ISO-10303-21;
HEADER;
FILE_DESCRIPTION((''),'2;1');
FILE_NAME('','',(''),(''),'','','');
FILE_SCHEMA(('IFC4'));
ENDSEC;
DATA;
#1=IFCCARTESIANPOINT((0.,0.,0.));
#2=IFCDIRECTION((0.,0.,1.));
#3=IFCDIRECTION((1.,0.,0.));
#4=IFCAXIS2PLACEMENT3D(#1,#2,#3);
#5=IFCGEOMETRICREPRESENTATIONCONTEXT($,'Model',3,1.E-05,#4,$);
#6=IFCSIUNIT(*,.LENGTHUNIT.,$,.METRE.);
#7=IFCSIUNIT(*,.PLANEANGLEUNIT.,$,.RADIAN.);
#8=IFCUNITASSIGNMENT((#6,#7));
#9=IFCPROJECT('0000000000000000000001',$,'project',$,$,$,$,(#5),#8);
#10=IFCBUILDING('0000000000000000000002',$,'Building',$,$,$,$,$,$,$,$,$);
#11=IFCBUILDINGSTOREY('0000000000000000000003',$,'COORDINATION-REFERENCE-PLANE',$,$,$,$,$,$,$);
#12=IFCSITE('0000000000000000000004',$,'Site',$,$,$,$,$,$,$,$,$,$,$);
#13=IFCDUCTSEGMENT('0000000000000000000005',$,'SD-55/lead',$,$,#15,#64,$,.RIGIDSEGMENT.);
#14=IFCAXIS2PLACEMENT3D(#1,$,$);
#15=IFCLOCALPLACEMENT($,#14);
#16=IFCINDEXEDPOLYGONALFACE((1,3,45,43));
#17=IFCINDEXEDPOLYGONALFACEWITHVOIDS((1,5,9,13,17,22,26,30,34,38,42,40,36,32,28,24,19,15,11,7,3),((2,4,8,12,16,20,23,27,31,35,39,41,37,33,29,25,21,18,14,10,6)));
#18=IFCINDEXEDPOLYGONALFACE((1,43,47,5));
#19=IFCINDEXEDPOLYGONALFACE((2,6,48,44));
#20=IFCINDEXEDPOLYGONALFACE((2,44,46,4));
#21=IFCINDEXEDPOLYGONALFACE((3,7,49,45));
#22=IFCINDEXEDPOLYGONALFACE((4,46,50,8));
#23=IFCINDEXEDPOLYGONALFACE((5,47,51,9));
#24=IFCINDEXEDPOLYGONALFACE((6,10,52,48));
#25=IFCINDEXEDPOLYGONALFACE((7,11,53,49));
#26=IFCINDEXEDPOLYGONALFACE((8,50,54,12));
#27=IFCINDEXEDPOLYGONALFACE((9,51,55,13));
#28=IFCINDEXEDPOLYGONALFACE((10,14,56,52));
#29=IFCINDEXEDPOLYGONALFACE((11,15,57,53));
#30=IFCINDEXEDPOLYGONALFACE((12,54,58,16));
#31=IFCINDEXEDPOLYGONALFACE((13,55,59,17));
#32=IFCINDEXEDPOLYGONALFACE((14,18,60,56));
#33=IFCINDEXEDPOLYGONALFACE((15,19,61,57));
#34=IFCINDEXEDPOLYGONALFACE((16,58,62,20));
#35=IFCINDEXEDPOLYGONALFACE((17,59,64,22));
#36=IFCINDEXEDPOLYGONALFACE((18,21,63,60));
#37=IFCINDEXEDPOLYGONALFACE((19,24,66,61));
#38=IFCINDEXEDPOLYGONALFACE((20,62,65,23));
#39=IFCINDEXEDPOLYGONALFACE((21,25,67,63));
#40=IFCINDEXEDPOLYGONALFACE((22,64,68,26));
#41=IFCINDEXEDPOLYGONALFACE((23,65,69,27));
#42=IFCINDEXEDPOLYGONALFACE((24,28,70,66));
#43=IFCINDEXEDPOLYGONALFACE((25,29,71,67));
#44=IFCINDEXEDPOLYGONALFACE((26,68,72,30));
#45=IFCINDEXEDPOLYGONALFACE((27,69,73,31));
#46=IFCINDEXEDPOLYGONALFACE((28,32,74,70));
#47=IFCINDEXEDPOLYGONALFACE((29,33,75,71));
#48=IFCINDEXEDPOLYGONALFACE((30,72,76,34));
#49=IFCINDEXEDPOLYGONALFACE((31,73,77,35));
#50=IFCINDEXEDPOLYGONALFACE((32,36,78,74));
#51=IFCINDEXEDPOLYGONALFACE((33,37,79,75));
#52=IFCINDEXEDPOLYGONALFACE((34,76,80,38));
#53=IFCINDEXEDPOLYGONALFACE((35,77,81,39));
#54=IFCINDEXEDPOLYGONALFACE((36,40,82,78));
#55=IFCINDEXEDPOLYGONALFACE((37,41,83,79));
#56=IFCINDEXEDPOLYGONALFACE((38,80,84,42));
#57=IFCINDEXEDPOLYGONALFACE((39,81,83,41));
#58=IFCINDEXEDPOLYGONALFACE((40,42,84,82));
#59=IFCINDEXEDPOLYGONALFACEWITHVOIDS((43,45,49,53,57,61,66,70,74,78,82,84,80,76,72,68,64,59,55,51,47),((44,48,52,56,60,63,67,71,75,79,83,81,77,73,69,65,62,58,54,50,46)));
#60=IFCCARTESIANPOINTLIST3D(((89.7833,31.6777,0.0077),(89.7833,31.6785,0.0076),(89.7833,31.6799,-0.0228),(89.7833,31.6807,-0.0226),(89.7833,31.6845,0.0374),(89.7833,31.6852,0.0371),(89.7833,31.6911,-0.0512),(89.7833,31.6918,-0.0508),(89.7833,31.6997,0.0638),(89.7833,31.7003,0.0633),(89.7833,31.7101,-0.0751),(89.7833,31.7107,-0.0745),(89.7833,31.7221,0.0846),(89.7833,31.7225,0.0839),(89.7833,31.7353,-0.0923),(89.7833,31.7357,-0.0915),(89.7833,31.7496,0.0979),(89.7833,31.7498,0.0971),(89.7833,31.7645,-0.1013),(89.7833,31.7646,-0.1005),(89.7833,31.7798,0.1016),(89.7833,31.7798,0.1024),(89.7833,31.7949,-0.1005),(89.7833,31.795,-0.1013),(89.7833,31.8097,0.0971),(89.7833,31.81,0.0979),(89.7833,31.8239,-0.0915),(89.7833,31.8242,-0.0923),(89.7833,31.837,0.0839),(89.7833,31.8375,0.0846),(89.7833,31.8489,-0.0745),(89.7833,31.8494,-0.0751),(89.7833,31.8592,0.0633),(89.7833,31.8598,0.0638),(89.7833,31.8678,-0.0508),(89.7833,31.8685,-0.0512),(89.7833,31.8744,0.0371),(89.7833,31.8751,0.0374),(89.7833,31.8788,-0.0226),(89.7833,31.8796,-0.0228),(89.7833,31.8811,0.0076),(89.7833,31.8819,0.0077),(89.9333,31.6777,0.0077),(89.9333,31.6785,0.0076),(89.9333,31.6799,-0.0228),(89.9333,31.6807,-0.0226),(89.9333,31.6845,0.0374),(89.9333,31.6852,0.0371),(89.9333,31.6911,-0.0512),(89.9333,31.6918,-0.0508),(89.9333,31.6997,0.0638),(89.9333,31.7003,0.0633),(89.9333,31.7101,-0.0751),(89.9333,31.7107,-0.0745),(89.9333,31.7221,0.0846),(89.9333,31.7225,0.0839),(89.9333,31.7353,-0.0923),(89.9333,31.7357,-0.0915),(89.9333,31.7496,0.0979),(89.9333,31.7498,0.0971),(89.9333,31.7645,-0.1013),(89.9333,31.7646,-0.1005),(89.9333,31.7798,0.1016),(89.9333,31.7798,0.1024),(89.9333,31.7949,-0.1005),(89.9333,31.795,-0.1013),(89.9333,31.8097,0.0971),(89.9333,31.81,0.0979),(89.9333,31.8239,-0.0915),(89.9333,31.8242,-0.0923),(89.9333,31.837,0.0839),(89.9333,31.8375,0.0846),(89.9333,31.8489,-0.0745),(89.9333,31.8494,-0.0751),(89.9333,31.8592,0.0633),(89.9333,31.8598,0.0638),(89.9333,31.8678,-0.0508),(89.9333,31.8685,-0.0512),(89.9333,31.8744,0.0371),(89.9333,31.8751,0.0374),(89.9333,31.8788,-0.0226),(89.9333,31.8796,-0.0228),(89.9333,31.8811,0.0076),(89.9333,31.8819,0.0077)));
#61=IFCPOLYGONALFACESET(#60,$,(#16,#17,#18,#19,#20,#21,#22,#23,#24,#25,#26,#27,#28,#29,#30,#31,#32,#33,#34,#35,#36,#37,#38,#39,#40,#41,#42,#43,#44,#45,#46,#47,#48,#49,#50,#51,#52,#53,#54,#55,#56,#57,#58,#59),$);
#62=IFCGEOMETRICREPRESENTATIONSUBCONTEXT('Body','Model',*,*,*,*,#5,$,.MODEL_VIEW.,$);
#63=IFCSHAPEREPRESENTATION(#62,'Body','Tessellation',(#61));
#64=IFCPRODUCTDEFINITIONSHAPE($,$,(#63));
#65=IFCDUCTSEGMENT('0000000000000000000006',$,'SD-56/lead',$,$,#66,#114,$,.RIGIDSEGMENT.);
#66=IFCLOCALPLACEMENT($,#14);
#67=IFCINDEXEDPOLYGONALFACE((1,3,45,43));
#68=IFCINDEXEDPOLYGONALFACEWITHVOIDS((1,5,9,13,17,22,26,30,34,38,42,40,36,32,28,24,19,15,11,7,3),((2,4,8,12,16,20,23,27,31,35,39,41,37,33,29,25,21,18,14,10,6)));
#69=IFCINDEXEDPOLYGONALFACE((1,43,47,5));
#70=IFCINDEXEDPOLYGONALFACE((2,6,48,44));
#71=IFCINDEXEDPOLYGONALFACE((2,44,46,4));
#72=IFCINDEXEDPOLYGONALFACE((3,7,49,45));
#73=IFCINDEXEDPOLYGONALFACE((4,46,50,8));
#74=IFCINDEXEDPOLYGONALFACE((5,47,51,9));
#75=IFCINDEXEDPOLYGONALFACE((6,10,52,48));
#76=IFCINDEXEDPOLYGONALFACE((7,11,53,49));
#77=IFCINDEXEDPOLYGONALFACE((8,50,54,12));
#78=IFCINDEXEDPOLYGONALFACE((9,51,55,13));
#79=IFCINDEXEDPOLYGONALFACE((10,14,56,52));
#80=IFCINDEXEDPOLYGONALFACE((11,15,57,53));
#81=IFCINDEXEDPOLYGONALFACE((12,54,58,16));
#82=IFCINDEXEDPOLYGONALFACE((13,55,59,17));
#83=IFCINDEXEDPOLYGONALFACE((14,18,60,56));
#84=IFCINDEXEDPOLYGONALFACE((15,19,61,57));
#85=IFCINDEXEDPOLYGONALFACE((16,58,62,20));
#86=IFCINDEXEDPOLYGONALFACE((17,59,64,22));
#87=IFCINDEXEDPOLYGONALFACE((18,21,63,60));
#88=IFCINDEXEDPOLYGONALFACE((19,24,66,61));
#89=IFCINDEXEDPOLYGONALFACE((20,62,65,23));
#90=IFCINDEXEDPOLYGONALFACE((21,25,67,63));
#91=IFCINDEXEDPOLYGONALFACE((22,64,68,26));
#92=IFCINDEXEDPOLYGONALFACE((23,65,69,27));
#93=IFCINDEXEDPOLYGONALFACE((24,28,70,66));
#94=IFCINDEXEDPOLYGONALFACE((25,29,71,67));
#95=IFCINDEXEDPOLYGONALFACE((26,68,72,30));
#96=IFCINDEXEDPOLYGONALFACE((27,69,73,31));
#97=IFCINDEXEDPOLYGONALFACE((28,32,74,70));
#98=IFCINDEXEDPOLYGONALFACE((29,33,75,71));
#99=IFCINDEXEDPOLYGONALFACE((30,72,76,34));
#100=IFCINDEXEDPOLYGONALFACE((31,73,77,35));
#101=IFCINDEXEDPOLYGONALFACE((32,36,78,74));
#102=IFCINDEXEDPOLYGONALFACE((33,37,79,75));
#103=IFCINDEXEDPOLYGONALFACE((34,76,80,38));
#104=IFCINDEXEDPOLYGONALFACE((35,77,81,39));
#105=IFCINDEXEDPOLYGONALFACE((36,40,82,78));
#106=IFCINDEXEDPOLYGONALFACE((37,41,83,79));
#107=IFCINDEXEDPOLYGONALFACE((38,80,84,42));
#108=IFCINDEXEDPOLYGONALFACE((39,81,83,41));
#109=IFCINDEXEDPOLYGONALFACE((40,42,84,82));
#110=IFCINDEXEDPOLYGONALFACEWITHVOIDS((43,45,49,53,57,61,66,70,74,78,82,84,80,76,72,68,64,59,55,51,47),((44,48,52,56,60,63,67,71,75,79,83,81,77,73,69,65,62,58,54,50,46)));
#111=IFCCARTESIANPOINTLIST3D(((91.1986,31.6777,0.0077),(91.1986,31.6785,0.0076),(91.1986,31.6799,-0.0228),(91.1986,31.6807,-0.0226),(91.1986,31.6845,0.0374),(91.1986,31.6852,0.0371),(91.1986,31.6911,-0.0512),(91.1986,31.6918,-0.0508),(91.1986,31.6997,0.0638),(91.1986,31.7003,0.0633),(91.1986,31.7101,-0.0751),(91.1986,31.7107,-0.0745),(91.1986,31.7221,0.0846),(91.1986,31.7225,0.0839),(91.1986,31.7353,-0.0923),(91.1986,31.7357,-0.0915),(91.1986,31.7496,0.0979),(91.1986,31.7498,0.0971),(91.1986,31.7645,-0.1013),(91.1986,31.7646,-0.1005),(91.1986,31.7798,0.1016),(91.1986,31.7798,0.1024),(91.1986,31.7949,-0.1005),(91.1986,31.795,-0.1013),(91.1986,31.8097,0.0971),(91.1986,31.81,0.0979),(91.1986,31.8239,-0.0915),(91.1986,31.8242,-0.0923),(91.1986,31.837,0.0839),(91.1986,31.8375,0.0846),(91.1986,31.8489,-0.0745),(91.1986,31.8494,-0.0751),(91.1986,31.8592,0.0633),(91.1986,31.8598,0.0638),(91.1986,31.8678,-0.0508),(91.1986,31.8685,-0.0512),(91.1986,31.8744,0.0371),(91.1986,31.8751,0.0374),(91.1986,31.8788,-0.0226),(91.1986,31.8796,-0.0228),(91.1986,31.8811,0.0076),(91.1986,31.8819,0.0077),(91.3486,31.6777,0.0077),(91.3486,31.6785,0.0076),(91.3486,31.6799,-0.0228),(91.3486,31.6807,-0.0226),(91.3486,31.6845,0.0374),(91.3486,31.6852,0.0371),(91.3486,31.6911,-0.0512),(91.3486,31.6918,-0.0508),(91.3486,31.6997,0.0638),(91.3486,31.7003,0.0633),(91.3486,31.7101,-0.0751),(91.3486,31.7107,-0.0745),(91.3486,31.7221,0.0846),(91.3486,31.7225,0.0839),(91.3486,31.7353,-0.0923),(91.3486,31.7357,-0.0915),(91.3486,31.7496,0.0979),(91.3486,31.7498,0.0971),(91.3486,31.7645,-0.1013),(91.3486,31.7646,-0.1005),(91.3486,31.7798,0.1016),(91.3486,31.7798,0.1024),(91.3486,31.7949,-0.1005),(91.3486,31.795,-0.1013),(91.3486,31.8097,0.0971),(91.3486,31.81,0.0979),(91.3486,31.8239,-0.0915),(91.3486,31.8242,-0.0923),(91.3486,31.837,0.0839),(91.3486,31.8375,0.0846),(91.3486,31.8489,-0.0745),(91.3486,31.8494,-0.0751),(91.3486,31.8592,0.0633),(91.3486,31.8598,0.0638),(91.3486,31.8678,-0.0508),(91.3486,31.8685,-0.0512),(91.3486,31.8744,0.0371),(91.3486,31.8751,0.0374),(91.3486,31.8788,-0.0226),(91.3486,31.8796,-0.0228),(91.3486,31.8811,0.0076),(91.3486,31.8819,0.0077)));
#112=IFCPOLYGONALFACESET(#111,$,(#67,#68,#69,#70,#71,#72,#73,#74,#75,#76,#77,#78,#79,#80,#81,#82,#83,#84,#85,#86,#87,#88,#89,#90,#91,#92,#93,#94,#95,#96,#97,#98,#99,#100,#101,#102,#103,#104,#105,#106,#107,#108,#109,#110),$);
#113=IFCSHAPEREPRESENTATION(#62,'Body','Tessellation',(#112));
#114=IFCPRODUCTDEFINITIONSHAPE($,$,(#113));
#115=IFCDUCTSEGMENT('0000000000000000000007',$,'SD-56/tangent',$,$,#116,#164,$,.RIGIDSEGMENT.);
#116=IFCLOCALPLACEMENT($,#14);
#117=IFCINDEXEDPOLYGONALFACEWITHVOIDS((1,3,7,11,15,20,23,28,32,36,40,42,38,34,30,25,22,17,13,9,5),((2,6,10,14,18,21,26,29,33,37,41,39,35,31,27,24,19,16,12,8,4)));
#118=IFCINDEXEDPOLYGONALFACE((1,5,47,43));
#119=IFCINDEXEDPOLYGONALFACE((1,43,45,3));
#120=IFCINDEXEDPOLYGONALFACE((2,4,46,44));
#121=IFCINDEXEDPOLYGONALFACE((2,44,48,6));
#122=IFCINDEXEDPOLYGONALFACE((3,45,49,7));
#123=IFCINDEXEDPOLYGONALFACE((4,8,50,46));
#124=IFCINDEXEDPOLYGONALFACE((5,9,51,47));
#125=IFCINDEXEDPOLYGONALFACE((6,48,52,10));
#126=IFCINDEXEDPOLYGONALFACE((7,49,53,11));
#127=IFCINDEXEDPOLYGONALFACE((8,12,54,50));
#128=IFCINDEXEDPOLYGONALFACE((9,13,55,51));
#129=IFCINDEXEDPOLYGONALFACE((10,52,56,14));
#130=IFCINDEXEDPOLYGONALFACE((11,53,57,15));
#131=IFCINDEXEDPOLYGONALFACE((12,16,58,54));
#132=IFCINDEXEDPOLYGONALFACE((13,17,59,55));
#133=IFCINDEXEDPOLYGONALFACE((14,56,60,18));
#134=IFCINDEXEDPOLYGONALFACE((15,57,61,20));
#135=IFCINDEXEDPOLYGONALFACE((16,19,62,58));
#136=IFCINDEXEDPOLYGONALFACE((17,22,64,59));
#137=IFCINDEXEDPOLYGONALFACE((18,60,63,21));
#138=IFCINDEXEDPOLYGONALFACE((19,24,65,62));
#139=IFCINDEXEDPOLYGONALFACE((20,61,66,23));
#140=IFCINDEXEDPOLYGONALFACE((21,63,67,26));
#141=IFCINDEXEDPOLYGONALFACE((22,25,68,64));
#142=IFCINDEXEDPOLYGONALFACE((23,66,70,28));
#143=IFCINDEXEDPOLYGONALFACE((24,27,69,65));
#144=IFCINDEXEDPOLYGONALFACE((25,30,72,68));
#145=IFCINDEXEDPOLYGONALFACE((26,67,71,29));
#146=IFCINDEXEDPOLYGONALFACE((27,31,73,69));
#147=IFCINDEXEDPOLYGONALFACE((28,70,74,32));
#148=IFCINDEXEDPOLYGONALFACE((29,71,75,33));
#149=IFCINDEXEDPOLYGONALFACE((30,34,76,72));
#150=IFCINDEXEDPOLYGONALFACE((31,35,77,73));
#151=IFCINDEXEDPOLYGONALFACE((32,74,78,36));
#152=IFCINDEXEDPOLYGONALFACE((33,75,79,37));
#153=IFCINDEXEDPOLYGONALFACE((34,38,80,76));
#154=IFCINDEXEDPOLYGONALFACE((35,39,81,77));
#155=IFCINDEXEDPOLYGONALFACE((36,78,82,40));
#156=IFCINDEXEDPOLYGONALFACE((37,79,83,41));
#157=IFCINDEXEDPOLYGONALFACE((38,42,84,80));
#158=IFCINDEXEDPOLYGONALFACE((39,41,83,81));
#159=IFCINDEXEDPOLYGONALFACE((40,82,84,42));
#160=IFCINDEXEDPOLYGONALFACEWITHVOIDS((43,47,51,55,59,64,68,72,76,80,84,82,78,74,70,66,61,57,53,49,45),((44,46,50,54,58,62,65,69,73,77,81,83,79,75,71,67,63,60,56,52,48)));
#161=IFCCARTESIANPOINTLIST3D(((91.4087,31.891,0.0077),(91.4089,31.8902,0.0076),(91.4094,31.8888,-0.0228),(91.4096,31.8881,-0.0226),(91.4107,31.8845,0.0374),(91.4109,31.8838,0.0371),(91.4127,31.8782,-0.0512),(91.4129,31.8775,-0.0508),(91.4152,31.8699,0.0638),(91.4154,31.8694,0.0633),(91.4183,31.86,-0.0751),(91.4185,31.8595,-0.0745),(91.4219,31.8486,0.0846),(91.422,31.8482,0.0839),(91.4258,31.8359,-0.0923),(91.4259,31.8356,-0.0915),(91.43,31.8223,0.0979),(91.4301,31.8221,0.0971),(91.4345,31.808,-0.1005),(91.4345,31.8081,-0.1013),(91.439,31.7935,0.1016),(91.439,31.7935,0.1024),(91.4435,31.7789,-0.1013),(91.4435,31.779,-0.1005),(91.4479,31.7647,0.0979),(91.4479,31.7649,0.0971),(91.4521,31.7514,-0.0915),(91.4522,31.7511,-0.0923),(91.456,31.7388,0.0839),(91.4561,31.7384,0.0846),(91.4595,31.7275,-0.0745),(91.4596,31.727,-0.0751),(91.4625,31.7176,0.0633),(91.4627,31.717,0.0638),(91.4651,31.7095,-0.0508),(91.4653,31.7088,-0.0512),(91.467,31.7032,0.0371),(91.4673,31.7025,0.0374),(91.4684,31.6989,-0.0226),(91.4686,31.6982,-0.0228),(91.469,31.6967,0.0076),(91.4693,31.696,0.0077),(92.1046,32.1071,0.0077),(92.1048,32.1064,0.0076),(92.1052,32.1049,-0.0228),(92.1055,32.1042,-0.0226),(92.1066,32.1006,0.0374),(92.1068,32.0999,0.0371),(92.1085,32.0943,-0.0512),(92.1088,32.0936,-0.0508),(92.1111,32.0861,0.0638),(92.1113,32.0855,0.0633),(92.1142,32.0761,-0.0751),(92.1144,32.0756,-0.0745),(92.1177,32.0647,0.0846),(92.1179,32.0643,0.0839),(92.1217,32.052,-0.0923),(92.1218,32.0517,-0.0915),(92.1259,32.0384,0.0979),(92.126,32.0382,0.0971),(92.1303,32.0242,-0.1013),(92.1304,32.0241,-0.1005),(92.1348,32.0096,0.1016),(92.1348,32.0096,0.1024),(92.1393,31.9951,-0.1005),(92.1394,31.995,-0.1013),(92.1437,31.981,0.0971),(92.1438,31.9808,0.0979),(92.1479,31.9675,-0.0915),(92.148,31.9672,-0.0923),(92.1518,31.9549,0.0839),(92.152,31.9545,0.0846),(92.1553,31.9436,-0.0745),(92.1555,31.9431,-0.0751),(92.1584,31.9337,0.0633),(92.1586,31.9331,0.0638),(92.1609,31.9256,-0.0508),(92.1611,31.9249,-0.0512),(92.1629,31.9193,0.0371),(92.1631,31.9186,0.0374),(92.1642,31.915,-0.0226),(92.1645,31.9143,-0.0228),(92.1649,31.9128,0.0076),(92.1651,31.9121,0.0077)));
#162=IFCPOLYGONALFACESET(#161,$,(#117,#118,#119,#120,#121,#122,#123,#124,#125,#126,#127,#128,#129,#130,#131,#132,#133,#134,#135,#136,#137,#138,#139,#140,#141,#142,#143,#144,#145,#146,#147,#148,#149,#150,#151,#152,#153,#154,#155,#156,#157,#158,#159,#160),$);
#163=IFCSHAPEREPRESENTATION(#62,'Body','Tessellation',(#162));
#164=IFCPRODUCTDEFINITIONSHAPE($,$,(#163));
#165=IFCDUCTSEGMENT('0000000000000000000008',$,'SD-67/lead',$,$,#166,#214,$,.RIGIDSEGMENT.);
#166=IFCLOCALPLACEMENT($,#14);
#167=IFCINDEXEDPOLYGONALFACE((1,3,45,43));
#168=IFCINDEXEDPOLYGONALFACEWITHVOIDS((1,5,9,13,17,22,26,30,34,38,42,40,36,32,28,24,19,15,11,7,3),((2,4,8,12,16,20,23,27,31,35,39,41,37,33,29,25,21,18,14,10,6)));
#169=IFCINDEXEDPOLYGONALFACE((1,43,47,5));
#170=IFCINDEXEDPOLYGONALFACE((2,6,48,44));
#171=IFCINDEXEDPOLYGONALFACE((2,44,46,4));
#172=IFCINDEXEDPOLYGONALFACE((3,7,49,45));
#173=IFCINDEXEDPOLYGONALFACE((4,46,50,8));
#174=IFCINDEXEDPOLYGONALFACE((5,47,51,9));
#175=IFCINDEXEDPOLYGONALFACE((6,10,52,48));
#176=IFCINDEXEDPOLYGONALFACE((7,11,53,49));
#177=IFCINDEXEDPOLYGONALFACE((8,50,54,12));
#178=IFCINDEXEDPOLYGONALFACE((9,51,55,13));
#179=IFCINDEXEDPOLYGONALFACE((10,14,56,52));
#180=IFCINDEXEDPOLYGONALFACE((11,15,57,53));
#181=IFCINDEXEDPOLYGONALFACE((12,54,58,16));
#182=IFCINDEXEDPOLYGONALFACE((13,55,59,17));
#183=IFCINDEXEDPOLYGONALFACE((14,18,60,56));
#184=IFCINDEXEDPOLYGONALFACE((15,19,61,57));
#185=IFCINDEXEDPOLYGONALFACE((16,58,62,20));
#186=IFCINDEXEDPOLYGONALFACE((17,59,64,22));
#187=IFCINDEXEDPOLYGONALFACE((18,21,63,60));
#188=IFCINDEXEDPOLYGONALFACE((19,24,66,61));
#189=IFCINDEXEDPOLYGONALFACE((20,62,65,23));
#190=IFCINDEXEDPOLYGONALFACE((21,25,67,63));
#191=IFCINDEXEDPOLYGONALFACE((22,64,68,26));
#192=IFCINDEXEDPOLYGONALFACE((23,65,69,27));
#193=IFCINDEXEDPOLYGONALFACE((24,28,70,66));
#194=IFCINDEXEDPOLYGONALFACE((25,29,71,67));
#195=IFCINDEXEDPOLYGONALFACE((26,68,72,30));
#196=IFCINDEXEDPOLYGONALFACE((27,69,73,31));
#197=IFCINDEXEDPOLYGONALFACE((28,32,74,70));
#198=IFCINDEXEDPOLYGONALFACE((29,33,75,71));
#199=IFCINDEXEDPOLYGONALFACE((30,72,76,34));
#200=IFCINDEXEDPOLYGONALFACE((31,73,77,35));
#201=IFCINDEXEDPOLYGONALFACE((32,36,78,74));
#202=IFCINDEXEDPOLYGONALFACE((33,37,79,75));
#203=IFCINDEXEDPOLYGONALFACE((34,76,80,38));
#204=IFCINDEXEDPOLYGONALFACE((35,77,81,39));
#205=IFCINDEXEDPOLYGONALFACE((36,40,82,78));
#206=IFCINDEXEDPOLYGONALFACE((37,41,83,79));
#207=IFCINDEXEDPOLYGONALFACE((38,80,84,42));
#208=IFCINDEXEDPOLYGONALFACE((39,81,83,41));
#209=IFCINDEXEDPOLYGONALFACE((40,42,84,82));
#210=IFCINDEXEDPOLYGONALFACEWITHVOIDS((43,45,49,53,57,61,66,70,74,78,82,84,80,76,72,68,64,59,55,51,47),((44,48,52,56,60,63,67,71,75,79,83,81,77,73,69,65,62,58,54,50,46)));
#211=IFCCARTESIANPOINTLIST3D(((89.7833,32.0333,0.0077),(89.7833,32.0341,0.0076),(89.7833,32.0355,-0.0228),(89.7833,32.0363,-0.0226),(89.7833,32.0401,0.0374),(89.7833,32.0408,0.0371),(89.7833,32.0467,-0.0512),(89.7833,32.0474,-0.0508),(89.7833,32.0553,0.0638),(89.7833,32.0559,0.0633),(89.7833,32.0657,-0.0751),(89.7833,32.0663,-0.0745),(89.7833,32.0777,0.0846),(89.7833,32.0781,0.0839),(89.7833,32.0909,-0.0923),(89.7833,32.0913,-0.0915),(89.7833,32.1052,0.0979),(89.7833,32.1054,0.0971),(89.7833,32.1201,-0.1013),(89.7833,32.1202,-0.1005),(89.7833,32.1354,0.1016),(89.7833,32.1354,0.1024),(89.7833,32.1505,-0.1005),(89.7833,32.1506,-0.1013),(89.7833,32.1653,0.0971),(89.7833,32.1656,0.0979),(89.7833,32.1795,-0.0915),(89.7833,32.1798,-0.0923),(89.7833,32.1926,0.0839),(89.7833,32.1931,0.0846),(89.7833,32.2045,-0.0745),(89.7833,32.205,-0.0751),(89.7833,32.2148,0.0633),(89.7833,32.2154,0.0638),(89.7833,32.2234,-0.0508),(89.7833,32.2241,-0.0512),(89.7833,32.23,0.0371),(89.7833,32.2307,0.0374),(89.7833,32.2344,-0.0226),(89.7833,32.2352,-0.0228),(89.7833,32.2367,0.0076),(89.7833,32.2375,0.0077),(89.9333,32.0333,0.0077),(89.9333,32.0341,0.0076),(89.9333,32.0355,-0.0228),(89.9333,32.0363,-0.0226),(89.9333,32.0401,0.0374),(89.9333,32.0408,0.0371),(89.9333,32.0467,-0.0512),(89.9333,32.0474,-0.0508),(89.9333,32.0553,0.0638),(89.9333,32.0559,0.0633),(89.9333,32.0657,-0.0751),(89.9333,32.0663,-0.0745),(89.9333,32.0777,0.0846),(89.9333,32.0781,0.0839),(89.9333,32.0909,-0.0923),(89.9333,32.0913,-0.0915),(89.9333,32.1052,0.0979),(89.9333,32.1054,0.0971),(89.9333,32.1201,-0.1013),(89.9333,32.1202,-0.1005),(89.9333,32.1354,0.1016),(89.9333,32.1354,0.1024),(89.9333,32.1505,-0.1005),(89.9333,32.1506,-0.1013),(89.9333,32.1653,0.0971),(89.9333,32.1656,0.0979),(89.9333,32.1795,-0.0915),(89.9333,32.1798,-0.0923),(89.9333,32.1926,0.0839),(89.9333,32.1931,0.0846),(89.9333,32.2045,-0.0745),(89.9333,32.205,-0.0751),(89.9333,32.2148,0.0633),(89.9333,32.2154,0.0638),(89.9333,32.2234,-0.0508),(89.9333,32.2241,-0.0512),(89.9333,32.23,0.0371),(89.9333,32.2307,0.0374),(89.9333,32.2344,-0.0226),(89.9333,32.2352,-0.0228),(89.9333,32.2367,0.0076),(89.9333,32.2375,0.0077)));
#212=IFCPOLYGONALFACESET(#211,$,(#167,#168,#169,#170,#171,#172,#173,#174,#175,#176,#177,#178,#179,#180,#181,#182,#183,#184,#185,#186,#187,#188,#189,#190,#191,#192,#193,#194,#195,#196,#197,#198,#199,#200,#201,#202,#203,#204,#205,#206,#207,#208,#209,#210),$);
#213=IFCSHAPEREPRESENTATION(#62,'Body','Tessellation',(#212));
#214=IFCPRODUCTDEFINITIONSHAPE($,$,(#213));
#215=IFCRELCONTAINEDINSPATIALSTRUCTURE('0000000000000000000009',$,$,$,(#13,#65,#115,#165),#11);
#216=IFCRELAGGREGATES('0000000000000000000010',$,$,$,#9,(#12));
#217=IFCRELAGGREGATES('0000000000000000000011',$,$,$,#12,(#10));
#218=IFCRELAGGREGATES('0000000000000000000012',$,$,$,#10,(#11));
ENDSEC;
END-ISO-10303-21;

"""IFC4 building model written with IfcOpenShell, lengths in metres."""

from ifc_helpers import new_model, si_unit, frame, origin_with_axes, place, context, subcontext, project, spatial, hollow_circle, extrude, element, save


model = new_model("IFC4")

# Units and contexts
model_context = context("Model", 3, precision=1e-05, world=origin_with_axes())
body_context_1 = subcontext(model_context, "Body", "Model", "MODEL_VIEW")
ifc_project = project(units=[si_unit("LENGTHUNIT", "METRE"), si_unit("PLANEANGLEUNIT", "RADIAN")], contexts=[model_context])

# Site, building, storey
site = spatial("IfcSite", under=ifc_project, Name="Site")
building = spatial("IfcBuilding", under=site, Name="Building")
storey = spatial("IfcBuildingStorey", under=building, Name="COORDINATION-REFERENCE-PLANE")

# Duct segments
for number, where, z_axis, x_axis, name in (
    (1, (89.9333, 31.7798, 0.0), (-1.0, 0.0, 0.0), (0.0, 0.0, 1.0), "SD-55/lead"),
    (2, (91.1986, 31.7798, 0.0), (1.0, 0.0, 0.0), (0.0, 0.0, 1.0), "SD-56/lead"),
):
    element("IfcDuctSegment", number, at=place(None, frame(where, z_axis=z_axis, x_axis=x_axis)), inside=storey, Name=name, PredefinedType="RIGIDSEGMENT", context=body_context_1, shape_type="SweptSolid", body=[
        extrude(hollow_circle(Radius=0.1024, WallThickness=0.0008), origin_with_axes(), (0.0, 0.0, 1.0), 0.15),
    ])

# Duct segment
duct_segment_1_placement = place(None, frame((91.439, 31.7935, 0.0), z_axis=(0.955005, 0.296589, 0.0), x_axis=(0.0, 0.0, 1.0)))
element("IfcDuctSegment", 3, at=duct_segment_1_placement, inside=storey, Name="SD-56/tangent", PredefinedType="RIGIDSEGMENT", context=body_context_1, shape_type="SweptSolid", body=[
    extrude(hollow_circle(Radius=0.1024, WallThickness=0.0008), origin_with_axes(), (0.0, 0.0, 1.0), 0.7286),
])

# Duct segment
for number, where, z_axis, x_axis, name in (
    (4, (89.9333, 32.1354, 0.0), (-1.0, 0.0, 0.0), (0.0, 0.0, 1.0), "SD-67/lead"),
):
    element("IfcDuctSegment", number, at=place(None, frame(where, z_axis=z_axis, x_axis=x_axis)), inside=storey, Name=name, PredefinedType="RIGIDSEGMENT", context=body_context_1, shape_type="SweptSolid", body=[
        extrude(hollow_circle(Radius=0.1024, WallThickness=0.0008), origin_with_axes(), (0.0, 0.0, 1.0), 0.15),
    ])

save(model, "model.ifc")
